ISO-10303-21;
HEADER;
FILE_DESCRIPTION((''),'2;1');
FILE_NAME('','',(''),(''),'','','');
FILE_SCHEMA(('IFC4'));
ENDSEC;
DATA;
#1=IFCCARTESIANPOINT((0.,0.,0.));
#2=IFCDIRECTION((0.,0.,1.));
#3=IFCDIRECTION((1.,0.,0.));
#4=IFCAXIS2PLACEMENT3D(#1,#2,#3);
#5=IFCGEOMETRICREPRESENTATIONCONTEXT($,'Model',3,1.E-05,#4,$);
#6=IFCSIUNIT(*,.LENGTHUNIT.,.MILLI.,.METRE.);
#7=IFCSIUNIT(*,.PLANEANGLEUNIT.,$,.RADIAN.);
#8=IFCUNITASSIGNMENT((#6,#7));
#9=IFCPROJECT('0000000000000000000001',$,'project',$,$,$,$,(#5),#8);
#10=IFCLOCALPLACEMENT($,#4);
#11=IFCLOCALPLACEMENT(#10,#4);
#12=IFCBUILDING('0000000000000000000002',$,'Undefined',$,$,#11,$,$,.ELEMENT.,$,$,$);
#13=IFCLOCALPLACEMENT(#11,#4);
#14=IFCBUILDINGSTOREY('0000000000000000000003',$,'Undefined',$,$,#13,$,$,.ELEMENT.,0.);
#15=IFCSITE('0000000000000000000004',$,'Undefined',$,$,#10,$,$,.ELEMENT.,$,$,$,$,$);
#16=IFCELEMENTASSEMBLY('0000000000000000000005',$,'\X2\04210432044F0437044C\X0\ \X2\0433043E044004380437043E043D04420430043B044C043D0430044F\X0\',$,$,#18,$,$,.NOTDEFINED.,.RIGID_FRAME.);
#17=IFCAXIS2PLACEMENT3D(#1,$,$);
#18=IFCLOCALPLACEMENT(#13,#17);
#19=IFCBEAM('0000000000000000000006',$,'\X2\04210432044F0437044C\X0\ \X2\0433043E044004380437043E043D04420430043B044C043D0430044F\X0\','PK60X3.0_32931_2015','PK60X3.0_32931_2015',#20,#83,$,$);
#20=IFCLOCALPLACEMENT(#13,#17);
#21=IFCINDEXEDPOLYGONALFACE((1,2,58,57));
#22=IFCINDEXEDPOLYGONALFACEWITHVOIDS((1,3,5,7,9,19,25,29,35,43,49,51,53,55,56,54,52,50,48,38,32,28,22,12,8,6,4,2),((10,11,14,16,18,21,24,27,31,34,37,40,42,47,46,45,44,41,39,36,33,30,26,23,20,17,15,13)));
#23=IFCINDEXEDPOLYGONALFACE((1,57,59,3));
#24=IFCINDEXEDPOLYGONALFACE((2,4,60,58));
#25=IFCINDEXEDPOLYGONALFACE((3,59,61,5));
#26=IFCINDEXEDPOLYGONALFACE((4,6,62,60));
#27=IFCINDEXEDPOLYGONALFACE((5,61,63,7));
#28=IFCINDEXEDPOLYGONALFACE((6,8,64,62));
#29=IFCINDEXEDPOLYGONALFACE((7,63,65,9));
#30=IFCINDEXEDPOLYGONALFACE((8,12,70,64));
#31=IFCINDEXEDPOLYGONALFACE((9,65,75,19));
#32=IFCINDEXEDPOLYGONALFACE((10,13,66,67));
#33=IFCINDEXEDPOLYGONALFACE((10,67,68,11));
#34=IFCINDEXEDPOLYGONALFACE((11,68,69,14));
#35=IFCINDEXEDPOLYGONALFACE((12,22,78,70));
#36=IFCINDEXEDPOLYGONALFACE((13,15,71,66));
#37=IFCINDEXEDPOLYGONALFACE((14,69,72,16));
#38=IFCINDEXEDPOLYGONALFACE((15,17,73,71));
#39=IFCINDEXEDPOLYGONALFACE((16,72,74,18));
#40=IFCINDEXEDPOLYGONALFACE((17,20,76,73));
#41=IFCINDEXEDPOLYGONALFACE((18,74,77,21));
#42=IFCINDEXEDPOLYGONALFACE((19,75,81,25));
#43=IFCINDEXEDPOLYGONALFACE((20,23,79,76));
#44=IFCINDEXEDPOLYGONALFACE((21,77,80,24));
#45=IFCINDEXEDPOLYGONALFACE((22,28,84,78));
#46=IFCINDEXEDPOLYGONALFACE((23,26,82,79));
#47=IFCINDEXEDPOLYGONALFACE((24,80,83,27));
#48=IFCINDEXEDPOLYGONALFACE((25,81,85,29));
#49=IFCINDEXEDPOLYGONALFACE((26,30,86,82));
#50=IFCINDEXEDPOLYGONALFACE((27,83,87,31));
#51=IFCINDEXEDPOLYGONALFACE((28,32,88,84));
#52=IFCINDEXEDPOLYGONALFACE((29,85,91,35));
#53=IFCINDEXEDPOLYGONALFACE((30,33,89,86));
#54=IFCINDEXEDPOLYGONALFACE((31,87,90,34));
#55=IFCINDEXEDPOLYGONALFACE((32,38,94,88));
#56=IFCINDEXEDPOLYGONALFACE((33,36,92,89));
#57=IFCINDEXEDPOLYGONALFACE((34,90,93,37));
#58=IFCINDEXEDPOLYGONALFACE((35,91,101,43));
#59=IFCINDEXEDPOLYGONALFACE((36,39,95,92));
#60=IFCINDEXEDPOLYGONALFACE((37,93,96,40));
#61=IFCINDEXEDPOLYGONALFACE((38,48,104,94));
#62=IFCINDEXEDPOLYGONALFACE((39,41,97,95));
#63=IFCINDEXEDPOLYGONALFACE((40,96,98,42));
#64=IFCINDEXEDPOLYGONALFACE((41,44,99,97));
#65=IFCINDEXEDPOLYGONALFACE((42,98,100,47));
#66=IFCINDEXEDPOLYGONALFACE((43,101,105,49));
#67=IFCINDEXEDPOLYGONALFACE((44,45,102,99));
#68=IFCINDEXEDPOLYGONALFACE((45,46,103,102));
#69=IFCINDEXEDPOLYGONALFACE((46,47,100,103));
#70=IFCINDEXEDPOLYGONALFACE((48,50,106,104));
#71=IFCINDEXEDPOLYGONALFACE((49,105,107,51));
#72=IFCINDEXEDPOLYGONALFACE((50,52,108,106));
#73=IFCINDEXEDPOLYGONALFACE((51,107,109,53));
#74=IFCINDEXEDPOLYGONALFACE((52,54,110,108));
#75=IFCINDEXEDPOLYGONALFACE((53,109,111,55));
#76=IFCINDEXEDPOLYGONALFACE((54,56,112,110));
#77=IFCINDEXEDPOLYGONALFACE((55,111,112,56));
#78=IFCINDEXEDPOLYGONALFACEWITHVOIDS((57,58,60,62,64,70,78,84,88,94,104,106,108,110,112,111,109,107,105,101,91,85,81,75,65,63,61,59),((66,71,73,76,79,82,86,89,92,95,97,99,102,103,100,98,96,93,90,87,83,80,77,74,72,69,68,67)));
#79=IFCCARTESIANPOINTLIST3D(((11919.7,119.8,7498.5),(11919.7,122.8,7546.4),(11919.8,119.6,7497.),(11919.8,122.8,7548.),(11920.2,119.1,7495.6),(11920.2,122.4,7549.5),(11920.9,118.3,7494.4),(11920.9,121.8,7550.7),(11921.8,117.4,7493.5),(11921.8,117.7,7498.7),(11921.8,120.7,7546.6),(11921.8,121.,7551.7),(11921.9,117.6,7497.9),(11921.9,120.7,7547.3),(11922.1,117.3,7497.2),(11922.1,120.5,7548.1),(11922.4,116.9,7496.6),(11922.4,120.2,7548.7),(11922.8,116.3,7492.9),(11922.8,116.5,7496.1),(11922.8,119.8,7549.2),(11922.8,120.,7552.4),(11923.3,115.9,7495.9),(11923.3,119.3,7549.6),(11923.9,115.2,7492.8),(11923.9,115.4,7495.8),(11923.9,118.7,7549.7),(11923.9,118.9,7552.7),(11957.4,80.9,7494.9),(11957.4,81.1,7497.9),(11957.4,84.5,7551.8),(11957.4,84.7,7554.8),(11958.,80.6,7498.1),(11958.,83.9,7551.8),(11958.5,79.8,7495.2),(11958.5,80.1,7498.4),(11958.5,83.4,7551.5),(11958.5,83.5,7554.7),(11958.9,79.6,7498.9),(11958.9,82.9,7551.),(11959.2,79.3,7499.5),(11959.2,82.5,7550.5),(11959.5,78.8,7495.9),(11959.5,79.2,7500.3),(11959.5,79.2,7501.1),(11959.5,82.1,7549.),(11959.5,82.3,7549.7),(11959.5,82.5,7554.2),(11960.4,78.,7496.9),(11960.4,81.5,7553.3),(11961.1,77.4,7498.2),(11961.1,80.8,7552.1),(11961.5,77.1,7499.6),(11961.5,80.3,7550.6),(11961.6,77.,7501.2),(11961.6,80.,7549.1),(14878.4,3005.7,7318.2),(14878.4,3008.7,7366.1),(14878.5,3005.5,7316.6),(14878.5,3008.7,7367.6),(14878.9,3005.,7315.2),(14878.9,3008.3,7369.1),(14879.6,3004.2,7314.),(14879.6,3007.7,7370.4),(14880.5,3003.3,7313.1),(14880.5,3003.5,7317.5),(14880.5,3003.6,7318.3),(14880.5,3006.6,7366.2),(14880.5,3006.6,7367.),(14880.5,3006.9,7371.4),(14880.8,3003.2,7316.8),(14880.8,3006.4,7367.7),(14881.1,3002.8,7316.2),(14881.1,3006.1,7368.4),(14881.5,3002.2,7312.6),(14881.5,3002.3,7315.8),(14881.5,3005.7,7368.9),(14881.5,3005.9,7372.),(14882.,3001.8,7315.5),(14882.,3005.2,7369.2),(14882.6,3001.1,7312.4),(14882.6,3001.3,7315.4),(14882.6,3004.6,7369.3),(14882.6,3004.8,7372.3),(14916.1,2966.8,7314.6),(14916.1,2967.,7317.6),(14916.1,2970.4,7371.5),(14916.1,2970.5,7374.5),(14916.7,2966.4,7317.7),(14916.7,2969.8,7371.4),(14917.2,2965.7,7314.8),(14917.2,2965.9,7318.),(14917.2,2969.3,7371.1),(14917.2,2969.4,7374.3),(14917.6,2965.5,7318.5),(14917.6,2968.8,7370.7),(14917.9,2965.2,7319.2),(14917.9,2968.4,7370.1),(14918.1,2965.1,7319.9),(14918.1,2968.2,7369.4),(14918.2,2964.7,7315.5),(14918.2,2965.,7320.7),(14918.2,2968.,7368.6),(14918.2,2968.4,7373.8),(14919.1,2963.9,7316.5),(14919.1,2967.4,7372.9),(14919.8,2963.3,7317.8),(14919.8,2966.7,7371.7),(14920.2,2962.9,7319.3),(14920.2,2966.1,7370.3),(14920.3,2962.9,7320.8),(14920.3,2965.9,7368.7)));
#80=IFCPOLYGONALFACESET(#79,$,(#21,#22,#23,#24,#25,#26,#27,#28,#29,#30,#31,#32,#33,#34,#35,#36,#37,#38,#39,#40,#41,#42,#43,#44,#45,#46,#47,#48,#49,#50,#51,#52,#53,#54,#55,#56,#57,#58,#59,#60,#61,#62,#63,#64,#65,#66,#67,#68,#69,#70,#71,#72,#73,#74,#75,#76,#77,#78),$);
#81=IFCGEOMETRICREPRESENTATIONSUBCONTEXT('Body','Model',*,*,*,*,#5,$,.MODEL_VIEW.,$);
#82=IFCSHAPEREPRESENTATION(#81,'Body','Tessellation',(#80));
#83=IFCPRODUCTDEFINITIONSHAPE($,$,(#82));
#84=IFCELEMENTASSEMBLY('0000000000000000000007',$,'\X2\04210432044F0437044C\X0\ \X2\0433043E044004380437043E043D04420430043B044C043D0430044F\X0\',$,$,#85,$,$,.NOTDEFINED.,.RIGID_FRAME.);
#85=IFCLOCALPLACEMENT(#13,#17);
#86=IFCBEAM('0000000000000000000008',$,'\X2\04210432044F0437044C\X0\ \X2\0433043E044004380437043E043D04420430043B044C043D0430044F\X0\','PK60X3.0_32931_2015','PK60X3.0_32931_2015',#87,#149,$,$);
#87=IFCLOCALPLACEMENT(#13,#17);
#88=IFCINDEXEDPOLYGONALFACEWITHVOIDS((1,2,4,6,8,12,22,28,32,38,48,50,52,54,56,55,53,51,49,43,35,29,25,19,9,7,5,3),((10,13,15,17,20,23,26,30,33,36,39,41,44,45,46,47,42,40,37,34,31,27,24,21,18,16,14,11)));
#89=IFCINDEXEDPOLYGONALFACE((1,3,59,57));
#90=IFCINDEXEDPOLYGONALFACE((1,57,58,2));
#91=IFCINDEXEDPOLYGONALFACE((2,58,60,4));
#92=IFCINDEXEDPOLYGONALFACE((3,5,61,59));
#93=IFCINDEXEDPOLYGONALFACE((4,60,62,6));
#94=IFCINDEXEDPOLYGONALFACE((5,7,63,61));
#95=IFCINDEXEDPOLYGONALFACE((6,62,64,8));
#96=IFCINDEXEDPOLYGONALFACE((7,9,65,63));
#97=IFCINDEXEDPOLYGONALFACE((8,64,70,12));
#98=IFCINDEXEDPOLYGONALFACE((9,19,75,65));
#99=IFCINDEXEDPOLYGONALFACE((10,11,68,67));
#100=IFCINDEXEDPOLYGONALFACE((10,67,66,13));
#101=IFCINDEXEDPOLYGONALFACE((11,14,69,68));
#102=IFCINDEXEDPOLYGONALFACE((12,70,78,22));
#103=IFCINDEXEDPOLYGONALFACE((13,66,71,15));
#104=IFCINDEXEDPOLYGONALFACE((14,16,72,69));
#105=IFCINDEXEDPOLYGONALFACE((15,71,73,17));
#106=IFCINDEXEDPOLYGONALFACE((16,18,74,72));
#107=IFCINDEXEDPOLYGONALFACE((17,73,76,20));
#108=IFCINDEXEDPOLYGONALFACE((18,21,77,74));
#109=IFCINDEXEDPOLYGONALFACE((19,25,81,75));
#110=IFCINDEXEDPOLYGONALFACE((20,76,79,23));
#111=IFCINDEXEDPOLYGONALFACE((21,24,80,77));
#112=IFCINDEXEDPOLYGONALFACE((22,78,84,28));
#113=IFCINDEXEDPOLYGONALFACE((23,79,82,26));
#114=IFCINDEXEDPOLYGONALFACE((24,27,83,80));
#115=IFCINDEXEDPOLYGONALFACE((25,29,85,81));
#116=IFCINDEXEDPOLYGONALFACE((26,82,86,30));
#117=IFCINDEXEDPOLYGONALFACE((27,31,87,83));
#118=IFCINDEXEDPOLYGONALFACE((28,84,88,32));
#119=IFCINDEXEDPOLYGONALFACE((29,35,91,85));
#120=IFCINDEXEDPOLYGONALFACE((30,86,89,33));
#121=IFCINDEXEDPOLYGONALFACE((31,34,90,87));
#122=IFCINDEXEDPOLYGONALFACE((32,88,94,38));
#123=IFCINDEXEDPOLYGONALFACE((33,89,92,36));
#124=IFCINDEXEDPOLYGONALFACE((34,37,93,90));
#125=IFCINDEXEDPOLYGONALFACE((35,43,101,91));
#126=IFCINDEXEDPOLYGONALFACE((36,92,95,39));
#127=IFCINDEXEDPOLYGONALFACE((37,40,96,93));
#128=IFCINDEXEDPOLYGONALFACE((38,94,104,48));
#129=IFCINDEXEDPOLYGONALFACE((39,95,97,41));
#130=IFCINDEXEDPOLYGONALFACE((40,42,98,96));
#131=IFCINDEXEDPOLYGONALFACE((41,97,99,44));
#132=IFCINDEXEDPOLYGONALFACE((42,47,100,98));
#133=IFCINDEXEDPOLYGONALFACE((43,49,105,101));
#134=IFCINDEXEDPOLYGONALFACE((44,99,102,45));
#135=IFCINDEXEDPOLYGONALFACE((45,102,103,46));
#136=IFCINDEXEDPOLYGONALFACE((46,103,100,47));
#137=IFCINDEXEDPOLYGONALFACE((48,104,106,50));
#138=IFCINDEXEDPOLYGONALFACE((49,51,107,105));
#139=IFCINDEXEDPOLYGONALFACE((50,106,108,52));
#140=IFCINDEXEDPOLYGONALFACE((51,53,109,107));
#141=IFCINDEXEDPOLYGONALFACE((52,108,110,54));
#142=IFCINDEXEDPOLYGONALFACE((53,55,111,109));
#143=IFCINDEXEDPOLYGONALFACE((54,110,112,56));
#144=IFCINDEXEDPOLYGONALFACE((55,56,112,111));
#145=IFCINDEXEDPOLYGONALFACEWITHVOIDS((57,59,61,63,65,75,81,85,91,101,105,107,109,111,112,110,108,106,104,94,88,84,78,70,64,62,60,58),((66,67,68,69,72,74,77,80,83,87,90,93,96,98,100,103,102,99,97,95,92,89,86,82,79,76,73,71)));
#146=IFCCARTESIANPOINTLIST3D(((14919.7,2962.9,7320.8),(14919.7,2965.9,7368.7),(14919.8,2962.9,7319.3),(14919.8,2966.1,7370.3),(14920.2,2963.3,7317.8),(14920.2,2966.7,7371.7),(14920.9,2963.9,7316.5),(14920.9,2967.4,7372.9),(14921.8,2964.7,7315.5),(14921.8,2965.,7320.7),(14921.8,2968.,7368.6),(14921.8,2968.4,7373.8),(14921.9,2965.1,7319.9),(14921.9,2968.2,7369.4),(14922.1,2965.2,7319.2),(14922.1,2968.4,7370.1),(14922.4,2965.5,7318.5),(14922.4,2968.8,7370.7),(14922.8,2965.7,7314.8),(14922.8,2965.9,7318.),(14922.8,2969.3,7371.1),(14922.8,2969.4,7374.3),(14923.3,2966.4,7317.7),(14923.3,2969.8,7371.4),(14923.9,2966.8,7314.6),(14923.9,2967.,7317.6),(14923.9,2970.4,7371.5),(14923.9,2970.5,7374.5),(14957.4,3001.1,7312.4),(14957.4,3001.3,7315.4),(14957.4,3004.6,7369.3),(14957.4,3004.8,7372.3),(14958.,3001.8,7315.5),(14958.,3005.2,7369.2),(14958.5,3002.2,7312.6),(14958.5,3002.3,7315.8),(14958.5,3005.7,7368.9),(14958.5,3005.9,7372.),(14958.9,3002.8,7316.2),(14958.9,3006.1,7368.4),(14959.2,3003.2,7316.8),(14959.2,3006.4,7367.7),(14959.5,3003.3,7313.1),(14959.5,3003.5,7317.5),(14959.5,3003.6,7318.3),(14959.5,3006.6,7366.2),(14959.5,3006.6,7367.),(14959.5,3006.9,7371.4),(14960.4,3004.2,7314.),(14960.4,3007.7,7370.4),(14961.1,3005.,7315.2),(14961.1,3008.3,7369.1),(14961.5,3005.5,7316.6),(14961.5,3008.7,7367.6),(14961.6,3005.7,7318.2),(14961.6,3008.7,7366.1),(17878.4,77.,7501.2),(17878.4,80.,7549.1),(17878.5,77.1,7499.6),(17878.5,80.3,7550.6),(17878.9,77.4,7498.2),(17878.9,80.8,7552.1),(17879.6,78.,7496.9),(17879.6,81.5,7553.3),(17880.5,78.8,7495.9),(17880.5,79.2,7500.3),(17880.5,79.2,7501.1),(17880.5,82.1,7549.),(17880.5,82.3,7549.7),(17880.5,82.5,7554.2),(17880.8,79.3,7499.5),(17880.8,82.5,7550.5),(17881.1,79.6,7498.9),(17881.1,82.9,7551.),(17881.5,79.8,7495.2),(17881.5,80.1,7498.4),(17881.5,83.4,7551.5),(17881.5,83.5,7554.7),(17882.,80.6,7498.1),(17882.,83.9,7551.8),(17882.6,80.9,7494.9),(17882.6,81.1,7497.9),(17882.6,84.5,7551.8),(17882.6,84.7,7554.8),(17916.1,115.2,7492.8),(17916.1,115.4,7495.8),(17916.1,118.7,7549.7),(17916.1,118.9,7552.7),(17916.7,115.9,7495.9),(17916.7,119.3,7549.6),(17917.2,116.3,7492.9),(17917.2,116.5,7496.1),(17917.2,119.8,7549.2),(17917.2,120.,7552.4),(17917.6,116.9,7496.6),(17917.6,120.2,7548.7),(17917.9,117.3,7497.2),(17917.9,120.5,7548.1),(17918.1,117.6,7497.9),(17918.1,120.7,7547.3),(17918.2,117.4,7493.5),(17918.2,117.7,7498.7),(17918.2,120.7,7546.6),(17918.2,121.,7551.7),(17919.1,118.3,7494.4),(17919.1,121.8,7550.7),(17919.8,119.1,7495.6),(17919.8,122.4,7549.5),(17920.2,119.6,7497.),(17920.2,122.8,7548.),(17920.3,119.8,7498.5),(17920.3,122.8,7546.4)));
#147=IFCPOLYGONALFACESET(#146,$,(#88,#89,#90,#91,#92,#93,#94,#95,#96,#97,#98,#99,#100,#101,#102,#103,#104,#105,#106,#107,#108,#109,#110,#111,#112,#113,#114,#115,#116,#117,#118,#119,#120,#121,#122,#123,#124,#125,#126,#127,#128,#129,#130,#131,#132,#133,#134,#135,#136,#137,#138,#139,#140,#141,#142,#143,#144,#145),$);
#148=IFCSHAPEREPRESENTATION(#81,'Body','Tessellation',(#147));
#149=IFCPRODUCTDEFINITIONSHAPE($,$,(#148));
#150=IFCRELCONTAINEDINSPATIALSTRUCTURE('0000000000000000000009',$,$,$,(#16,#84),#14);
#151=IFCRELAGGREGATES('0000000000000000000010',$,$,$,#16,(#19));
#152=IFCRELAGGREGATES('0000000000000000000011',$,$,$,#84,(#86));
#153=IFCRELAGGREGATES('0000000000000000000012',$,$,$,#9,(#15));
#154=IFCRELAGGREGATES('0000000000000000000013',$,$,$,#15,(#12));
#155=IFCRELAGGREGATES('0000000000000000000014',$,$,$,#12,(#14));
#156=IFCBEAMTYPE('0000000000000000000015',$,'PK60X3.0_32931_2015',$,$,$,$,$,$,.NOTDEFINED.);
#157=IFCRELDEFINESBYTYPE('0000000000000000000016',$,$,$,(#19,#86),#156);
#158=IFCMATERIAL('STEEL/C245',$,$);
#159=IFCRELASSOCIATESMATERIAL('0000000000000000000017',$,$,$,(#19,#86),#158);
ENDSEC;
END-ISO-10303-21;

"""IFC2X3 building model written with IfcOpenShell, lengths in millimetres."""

from ifc_helpers import new_model, si_unit, frame, origin_with_axes, origin_2d_with_axis, place, context, subcontext, project, spatial, hollow_rectangle, extrude, material, type_object, element, aggregate, save


model = new_model("IFC2X3")

# Units and contexts
model_context = context("Model", 3, precision=1e-05, world=origin_with_axes())
body_context = subcontext(model_context, "Body", "Model", "MODEL_VIEW")
ifc_project = project(units=[si_unit("LENGTHUNIT", "METRE", prefix="MILLI"), si_unit("PLANEANGLEUNIT", "RADIAN")], contexts=[model_context])

# Site, building, storey
site_placement = place(None, origin_with_axes())
site = spatial("IfcSite", under=ifc_project, at=site_placement, Name="Undefined", CompositionType="ELEMENT")
building_placement = place(site_placement, origin_with_axes())
building = spatial("IfcBuilding", under=site, at=building_placement, Name="Undefined", CompositionType="ELEMENT")
storey_placement = place(building_placement, origin_with_axes())
storey = spatial("IfcBuildingStorey", under=building, at=storey_placement, Name="Undefined", CompositionType="ELEMENT", Elevation=0.0)

# Shared definitions
ifc_material = material(Name="STEEL/C245")

# Element assemblies, beams
beam_type_1 = type_object("IfcBeamType", Name="PK60X3.0_32931_2015", PredefinedType="NOTDEFINED")
assembly_1_placement = place(storey_placement, origin_with_axes())
assembly_1 = element("IfcElementAssembly", 1, at=assembly_1_placement, inside=storey, Name="Связь горизонтальная", AssemblyPlace="NOTDEFINED", PredefinedType="RIGID_FRAME")
beam_1_placement = place(assembly_1_placement, frame((11940.7, 99.9, 7523.8), z_axis=(0.0, 0.062378, 0.998053), x_axis=(0.715179, 0.69758, -0.043599)))
beam_1 = element("IfcBeam", 2, at=beam_1_placement, type_object=beam_type_1, material=ifc_material, Name="Связь горизонтальная", Description="PK60X3.0_32931_2015", ObjectType="PK60X3.0_32931_2015", context=body_context, shape_type="SweptSolid", body=[
    extrude(hollow_rectangle(XDim=60.0, YDim=60.0, WallThickness=3.0, InnerFilletRadius=3.0, OuterFilletRadius=6.0, at=origin_2d_with_axis()), frame((4137.0, 0.0, 0.0), z_axis=(-1.0, 0.0, 0.0), x_axis=(0.0, -1.0, 0.0)), (0.0, 0.0, 1.0), 4137.0),
])
aggregate(assembly_1, [beam_1])
assembly_2_placement = place(storey_placement, origin_with_axes())
assembly_2 = element("IfcElementAssembly", 3, at=assembly_2_placement, inside=storey, Name="Связь горизонтальная", AssemblyPlace="NOTDEFINED", PredefinedType="RIGID_FRAME")
beam_2_placement = place(assembly_2_placement, frame((17899.3, 99.9, 7523.8), z_axis=(0.0, 0.062378, 0.998053), x_axis=(-0.715179, 0.69758, -0.043599)))
beam_2 = element("IfcBeam", 4, at=beam_2_placement, type_object=beam_type_1, material=ifc_material, Name="Связь горизонтальная", Description="PK60X3.0_32931_2015", ObjectType="PK60X3.0_32931_2015", context=body_context, shape_type="SweptSolid", body=[
    extrude(hollow_rectangle(XDim=60.0, YDim=60.0, WallThickness=3.0, InnerFilletRadius=3.0, OuterFilletRadius=6.0, at=origin_2d_with_axis()), frame((4137.0, 0.0, 0.0), z_axis=(-1.0, 0.0, 0.0), x_axis=(0.0, -1.0, 0.0)), (0.0, 0.0, 1.0), 4137.0),
])
aggregate(assembly_2, [beam_2])

save(model, "model.ifc")
